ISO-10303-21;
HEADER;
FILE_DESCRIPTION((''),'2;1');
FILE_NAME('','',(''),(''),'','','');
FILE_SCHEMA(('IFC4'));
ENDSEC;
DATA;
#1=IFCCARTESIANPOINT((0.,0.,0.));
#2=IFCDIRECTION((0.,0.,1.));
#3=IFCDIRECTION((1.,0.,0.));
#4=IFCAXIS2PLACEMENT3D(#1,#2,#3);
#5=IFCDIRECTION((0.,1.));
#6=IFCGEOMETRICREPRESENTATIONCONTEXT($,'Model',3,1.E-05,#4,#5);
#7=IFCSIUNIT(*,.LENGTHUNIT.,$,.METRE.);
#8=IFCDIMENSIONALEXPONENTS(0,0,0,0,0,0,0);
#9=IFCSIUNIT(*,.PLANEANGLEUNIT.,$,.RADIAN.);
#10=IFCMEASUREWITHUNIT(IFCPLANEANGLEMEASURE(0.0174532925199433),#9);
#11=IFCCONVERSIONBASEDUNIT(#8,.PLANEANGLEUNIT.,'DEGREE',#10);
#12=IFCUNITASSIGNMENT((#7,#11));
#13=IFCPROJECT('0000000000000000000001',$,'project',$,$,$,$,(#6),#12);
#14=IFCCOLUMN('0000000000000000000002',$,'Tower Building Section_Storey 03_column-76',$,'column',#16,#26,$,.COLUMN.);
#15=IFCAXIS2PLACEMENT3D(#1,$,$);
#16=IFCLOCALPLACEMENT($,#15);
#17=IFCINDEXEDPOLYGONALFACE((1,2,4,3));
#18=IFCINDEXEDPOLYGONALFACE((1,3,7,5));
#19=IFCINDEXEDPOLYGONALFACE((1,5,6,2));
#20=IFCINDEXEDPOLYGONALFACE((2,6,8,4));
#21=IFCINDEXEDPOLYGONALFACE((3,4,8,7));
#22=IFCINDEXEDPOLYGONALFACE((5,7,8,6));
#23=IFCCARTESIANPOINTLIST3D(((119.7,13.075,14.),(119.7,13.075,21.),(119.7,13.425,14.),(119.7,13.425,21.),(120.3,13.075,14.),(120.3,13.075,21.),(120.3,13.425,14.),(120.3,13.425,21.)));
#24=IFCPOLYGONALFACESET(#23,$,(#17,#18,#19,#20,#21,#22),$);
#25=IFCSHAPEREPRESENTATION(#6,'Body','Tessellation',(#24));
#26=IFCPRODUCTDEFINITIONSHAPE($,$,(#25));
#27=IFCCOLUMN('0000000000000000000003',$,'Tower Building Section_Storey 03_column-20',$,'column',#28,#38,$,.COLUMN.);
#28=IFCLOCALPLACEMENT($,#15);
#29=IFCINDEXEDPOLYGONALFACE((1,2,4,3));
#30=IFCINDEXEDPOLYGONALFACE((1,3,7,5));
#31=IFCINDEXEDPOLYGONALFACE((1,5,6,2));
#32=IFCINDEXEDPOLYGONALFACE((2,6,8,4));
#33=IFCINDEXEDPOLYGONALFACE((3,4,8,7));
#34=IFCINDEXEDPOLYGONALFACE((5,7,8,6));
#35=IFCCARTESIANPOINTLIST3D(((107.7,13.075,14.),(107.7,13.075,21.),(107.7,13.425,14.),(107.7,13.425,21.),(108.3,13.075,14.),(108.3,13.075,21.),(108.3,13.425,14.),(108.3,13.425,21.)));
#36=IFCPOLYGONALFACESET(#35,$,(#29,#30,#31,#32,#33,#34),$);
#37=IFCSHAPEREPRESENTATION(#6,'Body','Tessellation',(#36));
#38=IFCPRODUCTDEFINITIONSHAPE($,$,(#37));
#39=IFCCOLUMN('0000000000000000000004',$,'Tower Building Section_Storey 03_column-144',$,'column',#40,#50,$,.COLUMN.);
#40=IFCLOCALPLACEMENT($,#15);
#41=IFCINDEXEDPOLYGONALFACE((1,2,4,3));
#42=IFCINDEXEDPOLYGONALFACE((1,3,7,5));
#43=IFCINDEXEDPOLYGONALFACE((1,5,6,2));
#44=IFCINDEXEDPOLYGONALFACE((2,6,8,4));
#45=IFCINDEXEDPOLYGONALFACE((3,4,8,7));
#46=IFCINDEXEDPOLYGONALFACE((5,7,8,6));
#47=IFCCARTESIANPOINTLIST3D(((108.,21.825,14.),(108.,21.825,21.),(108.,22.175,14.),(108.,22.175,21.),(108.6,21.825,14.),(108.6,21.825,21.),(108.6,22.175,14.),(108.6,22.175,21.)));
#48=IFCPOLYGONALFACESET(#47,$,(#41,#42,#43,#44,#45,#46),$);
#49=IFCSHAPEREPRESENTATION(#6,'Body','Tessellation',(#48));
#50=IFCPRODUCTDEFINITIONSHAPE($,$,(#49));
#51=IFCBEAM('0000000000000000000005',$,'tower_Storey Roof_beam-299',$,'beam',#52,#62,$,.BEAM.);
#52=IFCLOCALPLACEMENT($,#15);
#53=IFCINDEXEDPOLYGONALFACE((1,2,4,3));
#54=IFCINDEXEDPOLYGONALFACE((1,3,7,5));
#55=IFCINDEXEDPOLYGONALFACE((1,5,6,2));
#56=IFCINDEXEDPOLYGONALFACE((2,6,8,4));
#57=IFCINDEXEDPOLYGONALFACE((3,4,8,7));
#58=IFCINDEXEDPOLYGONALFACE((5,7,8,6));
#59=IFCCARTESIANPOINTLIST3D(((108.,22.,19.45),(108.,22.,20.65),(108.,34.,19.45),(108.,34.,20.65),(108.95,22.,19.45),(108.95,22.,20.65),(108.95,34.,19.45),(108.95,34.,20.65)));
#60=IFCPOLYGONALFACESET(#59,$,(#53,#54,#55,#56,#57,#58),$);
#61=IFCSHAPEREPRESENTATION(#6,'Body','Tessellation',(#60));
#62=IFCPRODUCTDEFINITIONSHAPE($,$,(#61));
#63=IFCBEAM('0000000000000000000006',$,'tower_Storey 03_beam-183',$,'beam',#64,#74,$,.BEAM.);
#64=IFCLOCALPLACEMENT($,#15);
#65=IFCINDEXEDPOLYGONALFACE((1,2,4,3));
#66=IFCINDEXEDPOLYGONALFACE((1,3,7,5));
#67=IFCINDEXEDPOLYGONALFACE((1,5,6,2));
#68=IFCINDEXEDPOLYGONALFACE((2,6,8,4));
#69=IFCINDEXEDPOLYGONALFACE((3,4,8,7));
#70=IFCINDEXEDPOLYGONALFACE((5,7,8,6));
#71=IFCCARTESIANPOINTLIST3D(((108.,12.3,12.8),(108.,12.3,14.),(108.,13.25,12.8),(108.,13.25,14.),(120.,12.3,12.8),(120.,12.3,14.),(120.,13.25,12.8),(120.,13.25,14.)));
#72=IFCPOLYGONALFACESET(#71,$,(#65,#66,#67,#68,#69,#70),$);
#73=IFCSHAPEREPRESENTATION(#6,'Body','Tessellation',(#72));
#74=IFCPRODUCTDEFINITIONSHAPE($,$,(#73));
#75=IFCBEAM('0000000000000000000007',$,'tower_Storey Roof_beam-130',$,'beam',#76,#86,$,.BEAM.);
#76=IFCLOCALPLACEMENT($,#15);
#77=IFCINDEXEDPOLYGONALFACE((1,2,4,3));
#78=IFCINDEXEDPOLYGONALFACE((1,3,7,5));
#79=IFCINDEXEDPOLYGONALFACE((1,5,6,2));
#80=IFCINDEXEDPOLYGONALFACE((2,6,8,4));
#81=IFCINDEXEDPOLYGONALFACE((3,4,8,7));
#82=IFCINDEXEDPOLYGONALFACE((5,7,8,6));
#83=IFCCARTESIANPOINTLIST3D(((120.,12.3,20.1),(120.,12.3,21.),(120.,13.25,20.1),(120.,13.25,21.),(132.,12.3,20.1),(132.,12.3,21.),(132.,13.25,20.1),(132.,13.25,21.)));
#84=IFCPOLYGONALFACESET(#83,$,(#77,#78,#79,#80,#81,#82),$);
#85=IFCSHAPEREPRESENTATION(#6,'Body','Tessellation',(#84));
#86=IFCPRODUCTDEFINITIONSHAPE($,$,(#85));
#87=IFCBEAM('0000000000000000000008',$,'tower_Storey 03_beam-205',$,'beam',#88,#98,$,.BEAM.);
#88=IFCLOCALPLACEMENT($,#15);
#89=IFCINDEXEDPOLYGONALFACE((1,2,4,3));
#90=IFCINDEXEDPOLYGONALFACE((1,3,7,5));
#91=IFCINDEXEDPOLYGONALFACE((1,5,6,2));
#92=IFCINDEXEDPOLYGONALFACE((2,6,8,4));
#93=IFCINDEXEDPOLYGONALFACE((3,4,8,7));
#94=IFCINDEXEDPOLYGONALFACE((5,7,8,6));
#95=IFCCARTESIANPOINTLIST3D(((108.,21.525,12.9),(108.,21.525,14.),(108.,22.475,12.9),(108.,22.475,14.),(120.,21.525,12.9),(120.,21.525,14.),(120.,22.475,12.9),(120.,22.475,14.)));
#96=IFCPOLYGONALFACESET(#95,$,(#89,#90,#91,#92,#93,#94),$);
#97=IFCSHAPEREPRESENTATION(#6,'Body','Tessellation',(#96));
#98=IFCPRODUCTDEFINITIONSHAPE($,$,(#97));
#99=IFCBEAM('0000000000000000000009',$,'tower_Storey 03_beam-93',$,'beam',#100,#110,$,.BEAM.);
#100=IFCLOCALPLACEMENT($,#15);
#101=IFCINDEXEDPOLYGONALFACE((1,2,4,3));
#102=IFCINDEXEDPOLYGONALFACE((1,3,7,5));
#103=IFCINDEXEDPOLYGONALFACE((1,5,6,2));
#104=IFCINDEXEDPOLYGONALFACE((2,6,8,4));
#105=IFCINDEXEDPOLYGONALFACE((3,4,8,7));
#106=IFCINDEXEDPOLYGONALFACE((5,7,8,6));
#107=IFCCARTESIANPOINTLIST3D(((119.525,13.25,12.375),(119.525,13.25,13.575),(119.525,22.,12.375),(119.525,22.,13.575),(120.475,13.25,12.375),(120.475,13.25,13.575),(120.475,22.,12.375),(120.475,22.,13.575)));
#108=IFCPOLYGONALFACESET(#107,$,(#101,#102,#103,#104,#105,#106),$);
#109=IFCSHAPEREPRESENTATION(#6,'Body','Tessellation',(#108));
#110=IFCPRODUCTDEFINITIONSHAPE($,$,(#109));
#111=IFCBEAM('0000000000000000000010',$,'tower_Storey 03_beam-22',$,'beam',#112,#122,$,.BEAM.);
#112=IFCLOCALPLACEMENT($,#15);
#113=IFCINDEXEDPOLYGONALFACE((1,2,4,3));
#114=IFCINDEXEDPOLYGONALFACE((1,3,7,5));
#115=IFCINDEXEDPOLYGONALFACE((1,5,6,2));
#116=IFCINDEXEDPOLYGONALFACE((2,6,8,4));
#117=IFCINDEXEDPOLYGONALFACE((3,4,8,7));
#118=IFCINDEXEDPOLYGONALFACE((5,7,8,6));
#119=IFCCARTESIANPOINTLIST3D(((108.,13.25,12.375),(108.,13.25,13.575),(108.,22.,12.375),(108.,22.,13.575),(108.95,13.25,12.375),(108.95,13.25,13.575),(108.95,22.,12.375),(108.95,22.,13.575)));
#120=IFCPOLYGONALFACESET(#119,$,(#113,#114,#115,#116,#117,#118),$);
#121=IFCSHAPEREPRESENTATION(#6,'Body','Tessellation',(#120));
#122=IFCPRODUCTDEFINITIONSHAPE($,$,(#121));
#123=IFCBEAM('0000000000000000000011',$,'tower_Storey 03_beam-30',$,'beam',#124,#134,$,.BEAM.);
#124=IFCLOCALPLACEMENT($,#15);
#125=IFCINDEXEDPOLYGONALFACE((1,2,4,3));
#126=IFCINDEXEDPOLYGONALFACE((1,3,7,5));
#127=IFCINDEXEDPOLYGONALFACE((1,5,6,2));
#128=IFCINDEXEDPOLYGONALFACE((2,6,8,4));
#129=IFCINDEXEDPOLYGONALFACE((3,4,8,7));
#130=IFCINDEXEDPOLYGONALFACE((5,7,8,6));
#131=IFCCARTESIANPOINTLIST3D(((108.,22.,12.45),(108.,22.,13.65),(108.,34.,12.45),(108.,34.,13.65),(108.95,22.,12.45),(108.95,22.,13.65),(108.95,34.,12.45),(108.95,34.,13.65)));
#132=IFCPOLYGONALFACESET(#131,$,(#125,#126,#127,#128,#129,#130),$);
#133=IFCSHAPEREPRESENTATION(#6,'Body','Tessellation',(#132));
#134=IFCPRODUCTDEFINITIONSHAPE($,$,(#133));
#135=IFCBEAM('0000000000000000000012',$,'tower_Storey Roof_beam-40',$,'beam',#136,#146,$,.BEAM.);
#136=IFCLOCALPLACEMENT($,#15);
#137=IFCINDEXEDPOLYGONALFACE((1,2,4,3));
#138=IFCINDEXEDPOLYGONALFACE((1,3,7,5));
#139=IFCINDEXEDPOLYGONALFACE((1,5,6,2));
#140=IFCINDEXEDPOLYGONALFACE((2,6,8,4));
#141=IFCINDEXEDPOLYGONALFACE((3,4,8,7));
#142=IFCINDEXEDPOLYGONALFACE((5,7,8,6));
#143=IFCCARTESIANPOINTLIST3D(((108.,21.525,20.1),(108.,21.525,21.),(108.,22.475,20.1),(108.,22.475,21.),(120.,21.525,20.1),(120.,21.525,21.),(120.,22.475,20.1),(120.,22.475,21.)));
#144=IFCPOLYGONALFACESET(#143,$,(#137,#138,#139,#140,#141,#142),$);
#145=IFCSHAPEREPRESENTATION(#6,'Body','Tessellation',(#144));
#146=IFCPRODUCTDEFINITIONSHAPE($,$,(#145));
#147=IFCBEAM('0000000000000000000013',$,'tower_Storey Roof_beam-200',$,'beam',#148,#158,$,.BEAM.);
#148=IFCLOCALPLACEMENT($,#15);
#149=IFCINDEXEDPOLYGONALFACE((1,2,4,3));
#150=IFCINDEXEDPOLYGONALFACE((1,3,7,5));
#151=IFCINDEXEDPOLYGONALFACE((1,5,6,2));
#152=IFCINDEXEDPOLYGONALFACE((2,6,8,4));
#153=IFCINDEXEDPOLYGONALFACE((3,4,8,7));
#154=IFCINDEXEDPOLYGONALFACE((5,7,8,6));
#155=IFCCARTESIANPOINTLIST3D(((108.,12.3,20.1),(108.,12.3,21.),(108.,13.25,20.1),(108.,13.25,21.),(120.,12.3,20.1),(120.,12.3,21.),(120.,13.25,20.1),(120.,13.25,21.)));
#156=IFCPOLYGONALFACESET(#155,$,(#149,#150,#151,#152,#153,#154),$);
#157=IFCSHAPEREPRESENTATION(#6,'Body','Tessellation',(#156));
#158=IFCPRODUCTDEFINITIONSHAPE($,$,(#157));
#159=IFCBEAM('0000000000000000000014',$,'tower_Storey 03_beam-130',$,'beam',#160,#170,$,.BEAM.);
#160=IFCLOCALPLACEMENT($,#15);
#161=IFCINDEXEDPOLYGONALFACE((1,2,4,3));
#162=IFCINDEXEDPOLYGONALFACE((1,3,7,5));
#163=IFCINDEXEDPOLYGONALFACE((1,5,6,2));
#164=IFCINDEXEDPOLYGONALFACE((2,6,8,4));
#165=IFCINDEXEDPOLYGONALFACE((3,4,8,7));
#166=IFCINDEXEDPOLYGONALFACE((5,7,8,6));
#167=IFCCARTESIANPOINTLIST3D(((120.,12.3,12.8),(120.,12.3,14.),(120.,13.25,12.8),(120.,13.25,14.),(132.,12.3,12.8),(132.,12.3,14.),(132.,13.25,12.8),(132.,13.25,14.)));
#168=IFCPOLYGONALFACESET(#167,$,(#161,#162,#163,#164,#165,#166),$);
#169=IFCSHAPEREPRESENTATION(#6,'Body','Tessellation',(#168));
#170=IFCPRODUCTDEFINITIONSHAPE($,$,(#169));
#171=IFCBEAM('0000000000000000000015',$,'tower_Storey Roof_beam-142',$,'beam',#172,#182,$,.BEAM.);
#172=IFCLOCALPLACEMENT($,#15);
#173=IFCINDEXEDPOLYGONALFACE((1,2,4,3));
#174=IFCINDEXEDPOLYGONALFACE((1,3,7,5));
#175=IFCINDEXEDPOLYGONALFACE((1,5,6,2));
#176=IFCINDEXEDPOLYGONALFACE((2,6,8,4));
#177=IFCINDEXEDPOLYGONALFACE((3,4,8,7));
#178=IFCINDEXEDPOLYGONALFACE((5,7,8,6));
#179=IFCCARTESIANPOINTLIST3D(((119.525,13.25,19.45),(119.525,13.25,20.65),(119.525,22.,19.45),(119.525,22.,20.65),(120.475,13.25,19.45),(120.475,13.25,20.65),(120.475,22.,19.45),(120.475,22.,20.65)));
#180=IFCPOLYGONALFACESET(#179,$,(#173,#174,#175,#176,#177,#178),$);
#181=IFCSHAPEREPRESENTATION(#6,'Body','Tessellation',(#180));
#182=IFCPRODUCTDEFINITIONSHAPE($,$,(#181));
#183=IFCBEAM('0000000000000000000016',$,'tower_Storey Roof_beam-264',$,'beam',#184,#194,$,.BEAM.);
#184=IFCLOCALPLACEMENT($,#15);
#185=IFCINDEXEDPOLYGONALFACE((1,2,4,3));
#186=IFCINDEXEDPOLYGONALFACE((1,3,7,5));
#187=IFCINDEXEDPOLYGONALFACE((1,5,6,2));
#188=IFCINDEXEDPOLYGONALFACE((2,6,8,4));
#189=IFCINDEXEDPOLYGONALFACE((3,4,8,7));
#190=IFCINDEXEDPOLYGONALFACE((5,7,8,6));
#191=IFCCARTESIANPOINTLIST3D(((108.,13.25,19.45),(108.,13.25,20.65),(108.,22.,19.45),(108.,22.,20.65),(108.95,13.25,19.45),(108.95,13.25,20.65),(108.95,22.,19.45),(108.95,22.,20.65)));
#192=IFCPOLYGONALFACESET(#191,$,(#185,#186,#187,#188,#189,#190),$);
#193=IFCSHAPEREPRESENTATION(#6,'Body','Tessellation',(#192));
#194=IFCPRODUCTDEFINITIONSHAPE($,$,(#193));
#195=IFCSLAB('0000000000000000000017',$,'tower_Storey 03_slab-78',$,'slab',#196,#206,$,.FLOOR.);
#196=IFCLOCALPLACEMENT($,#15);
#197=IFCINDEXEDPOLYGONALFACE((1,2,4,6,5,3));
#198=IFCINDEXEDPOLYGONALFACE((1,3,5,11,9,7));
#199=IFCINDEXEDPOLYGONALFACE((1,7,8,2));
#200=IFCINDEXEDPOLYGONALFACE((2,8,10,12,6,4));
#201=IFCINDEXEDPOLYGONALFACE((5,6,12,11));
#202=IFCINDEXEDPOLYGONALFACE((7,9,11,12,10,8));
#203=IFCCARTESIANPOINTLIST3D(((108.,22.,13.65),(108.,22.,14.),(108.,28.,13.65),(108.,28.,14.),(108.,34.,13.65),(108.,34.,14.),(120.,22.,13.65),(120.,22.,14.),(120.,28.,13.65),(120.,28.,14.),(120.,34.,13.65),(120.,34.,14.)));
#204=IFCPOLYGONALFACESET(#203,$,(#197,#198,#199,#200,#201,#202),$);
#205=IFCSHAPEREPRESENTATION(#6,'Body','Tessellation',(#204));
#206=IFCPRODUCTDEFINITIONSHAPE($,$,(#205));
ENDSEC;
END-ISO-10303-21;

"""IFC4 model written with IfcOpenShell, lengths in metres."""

from ifc_helpers import new_model, entity, si_unit, converted_unit, direction, frame, origin_with_axes, place, context, project, polyline, outline, extrude, element, save


model = new_model("IFC4")

# Units and contexts
model_context = context("Model", 3, precision=1e-05, world=origin_with_axes(), true_north=direction((0.0, 1.0)))
ifc_project = project(units=[si_unit("LENGTHUNIT", "METRE"), converted_unit("PLANEANGLEUNIT", "DEGREE", entity("IfcPlaneAngleMeasure", 0.0174532925199433), si_unit("PLANEANGLEUNIT", "RADIAN"), dimensions=[0, 0, 0, 0, 0, 0, 0])], contexts=[model_context])

# Columns
placement_1 = place(None, origin_with_axes())
placement_2 = place(placement_1, frame((0.0, 0.0, 14.0), z_axis=(0.0, 0.0, 1.0), x_axis=(1.0, 0.0, 0.0)))
for number, where, z_axis, x_axis, name in (
    (1, (120.0, 13.25, 0.0), (0.0, 0.0, 1.0), (1.0, 0.0, 0.0), "Tower Building Section_Storey 03_column-76"),
    (2, (108.0, 13.25, 0.0), (0.0, 0.0, 1.0), (1.0, 0.0, 0.0), "Tower Building Section_Storey 03_column-20"),
    (3, (108.3, 22.0, 0.0), (0.0, 0.0, 1.0), (1.0, 0.0, 0.0), "Tower Building Section_Storey 03_column-144"),
):
    element("IfcColumn", number, at=place(placement_2, frame(where, z_axis=z_axis, x_axis=x_axis)), Name=name, ObjectType="column", PredefinedType="COLUMN", context=model_context, body=[
        extrude(outline(polyline([(-0.3, -0.175, 0.0), (0.3, -0.175, 0.0), (0.3, 0.175, 0.0), (-0.3, 0.175, 0.0), (-0.3, -0.175, 0.0)])), origin_with_axes(), (0.0, 0.0, 1.0), 7.0),
    ])

# Beams
placement_3 = place(placement_1, frame((0.0, 0.0, 21.0), z_axis=(0.0, 0.0, 1.0), x_axis=(1.0, 0.0, 0.0)))
beam_1_placement = place(placement_3, frame((108.475, 22.0, -0.95), z_axis=(0.0, 1.0, 0.0), x_axis=(-1.0, 0.0, 0.0)))
element("IfcBeam", 4, at=beam_1_placement, Name="tower_Storey Roof_beam-299", ObjectType="beam", PredefinedType="BEAM", context=model_context, body=[
    extrude(outline(polyline([(0.475, 0.6, 0.0), (-0.475, 0.6, 0.0), (-0.475, -0.6, 0.0), (0.475, -0.6, 0.0), (0.475, 0.6, 0.0)])), origin_with_axes(), (0.0, 0.0, 1.0), 12.0),
])
beam_2_placement = place(placement_2, frame((108.0, 12.775, -0.6), z_axis=(1.0, 0.0, 0.0), x_axis=(0.0, 1.0, 0.0)))
element("IfcBeam", 5, at=beam_2_placement, Name="tower_Storey 03_beam-183", ObjectType="beam", PredefinedType="BEAM", context=model_context, body=[
    extrude(outline(polyline([(0.475, 0.6, 0.0), (-0.475, 0.6, 0.0), (-0.475, -0.6, 0.0), (0.475, -0.6, 0.0), (0.475, 0.6, 0.0)])), origin_with_axes(), (0.0, 0.0, 1.0), 12.0),
])
beam_3_placement = place(placement_3, frame((120.0, 12.775, -0.45), z_axis=(1.0, 0.0, 0.0), x_axis=(0.0, 1.0, 0.0)))
element("IfcBeam", 6, at=beam_3_placement, Name="tower_Storey Roof_beam-130", ObjectType="beam", PredefinedType="BEAM", context=model_context, body=[
    extrude(outline(polyline([(0.475, 0.45, 0.0), (-0.475, 0.45, 0.0), (-0.475, -0.45, 0.0), (0.475, -0.45, 0.0), (0.475, 0.45, 0.0)])), origin_with_axes(), (0.0, 0.0, 1.0), 12.0),
])
beam_4_placement = place(placement_2, frame((108.0, 22.0, -0.55), z_axis=(1.0, 0.0, 0.0), x_axis=(0.0, 1.0, 0.0)))
element("IfcBeam", 7, at=beam_4_placement, Name="tower_Storey 03_beam-205", ObjectType="beam", PredefinedType="BEAM", context=model_context, body=[
    extrude(outline(polyline([(0.475, 0.55, 0.0), (-0.475, 0.55, 0.0), (-0.475, -0.55, 0.0), (0.475, -0.55, 0.0), (0.475, 0.55, 0.0)])), origin_with_axes(), (0.0, 0.0, 1.0), 12.0),
])
for number, where, z_axis, x_axis, name in (
    (8, (120.0, 13.25, -1.025), (0.0, 1.0, 0.0), (-1.0, 0.0, 0.0), "tower_Storey 03_beam-93"),
    (9, (108.475, 13.25, -1.025), (0.0, 1.0, 0.0), (-1.0, 0.0, 0.0), "tower_Storey 03_beam-22"),
):
    element("IfcBeam", number, at=place(placement_2, frame(where, z_axis=z_axis, x_axis=x_axis)), Name=name, ObjectType="beam", PredefinedType="BEAM", context=model_context, body=[
        extrude(outline(polyline([(0.475, 0.6, 0.0), (-0.475, 0.6, 0.0), (-0.475, -0.6, 0.0), (0.475, -0.6, 0.0), (0.475, 0.6, 0.0)])), origin_with_axes(), (0.0, 0.0, 1.0), 8.75),
    ])
beam_5_placement = place(placement_2, frame((108.475, 22.0, -0.95), z_axis=(0.0, 1.0, 0.0), x_axis=(-1.0, 0.0, 0.0)))
element("IfcBeam", 10, at=beam_5_placement, Name="tower_Storey 03_beam-30", ObjectType="beam", PredefinedType="BEAM", context=model_context, body=[
    extrude(outline(polyline([(0.475, 0.6, 0.0), (-0.475, 0.6, 0.0), (-0.475, -0.6, 0.0), (0.475, -0.6, 0.0), (0.475, 0.6, 0.0)])), origin_with_axes(), (0.0, 0.0, 1.0), 12.0),
])
for number, where, z_axis, x_axis, name in (
    (11, (108.0, 22.0, -0.45), (1.0, 0.0, 0.0), (0.0, 1.0, 0.0), "tower_Storey Roof_beam-40"),
    (12, (108.0, 12.775, -0.45), (1.0, 0.0, 0.0), (0.0, 1.0, 0.0), "tower_Storey Roof_beam-200"),
):
    element("IfcBeam", number, at=place(placement_3, frame(where, z_axis=z_axis, x_axis=x_axis)), Name=name, ObjectType="beam", PredefinedType="BEAM", context=model_context, body=[
        extrude(outline(polyline([(0.475, 0.45, 0.0), (-0.475, 0.45, 0.0), (-0.475, -0.45, 0.0), (0.475, -0.45, 0.0), (0.475, 0.45, 0.0)])), origin_with_axes(), (0.0, 0.0, 1.0), 12.0),
    ])
beam_6_placement = place(placement_2, frame((120.0, 12.775, -0.6), z_axis=(1.0, 0.0, 0.0), x_axis=(0.0, 1.0, 0.0)))
element("IfcBeam", 13, at=beam_6_placement, Name="tower_Storey 03_beam-130", ObjectType="beam", PredefinedType="BEAM", context=model_context, body=[
    extrude(outline(polyline([(0.475, 0.6, 0.0), (-0.475, 0.6, 0.0), (-0.475, -0.6, 0.0), (0.475, -0.6, 0.0), (0.475, 0.6, 0.0)])), origin_with_axes(), (0.0, 0.0, 1.0), 12.0),
])
for number, where, z_axis, x_axis, name in (
    (14, (120.0, 13.25, -0.95), (0.0, 1.0, 0.0), (-1.0, 0.0, 0.0), "tower_Storey Roof_beam-142"),
    (15, (108.475, 13.25, -0.95), (0.0, 1.0, 0.0), (-1.0, 0.0, 0.0), "tower_Storey Roof_beam-264"),
):
    element("IfcBeam", number, at=place(placement_3, frame(where, z_axis=z_axis, x_axis=x_axis)), Name=name, ObjectType="beam", PredefinedType="BEAM", context=model_context, body=[
        extrude(outline(polyline([(0.475, 0.6, 0.0), (-0.475, 0.6, 0.0), (-0.475, -0.6, 0.0), (0.475, -0.6, 0.0), (0.475, 0.6, 0.0)])), origin_with_axes(), (0.0, 0.0, 1.0), 8.75),
    ])

# Slab
slab_1_placement = place(placement_2, frame((114.0, 28.0, -0.35), z_axis=(0.0, 0.0, 1.0), x_axis=(1.0, 0.0, 0.0)))
element("IfcSlab", 16, at=slab_1_placement, Name="tower_Storey 03_slab-78", ObjectType="slab", PredefinedType="FLOOR", context=model_context, body=[
    extrude(outline(polyline([(-6.0, -6.0, 0.0), (6.0, -6.0, 0.0), (6.0, 0.0, 0.0), (6.0, 6.0, 0.0), (-6.0, 6.0, 0.0), (-6.0, 0.0, 0.0), (-6.0, -6.0, 0.0)])), origin_with_axes(), (0.0, 0.0, 1.0), 0.35),
])

save(model, "model.ifc")
